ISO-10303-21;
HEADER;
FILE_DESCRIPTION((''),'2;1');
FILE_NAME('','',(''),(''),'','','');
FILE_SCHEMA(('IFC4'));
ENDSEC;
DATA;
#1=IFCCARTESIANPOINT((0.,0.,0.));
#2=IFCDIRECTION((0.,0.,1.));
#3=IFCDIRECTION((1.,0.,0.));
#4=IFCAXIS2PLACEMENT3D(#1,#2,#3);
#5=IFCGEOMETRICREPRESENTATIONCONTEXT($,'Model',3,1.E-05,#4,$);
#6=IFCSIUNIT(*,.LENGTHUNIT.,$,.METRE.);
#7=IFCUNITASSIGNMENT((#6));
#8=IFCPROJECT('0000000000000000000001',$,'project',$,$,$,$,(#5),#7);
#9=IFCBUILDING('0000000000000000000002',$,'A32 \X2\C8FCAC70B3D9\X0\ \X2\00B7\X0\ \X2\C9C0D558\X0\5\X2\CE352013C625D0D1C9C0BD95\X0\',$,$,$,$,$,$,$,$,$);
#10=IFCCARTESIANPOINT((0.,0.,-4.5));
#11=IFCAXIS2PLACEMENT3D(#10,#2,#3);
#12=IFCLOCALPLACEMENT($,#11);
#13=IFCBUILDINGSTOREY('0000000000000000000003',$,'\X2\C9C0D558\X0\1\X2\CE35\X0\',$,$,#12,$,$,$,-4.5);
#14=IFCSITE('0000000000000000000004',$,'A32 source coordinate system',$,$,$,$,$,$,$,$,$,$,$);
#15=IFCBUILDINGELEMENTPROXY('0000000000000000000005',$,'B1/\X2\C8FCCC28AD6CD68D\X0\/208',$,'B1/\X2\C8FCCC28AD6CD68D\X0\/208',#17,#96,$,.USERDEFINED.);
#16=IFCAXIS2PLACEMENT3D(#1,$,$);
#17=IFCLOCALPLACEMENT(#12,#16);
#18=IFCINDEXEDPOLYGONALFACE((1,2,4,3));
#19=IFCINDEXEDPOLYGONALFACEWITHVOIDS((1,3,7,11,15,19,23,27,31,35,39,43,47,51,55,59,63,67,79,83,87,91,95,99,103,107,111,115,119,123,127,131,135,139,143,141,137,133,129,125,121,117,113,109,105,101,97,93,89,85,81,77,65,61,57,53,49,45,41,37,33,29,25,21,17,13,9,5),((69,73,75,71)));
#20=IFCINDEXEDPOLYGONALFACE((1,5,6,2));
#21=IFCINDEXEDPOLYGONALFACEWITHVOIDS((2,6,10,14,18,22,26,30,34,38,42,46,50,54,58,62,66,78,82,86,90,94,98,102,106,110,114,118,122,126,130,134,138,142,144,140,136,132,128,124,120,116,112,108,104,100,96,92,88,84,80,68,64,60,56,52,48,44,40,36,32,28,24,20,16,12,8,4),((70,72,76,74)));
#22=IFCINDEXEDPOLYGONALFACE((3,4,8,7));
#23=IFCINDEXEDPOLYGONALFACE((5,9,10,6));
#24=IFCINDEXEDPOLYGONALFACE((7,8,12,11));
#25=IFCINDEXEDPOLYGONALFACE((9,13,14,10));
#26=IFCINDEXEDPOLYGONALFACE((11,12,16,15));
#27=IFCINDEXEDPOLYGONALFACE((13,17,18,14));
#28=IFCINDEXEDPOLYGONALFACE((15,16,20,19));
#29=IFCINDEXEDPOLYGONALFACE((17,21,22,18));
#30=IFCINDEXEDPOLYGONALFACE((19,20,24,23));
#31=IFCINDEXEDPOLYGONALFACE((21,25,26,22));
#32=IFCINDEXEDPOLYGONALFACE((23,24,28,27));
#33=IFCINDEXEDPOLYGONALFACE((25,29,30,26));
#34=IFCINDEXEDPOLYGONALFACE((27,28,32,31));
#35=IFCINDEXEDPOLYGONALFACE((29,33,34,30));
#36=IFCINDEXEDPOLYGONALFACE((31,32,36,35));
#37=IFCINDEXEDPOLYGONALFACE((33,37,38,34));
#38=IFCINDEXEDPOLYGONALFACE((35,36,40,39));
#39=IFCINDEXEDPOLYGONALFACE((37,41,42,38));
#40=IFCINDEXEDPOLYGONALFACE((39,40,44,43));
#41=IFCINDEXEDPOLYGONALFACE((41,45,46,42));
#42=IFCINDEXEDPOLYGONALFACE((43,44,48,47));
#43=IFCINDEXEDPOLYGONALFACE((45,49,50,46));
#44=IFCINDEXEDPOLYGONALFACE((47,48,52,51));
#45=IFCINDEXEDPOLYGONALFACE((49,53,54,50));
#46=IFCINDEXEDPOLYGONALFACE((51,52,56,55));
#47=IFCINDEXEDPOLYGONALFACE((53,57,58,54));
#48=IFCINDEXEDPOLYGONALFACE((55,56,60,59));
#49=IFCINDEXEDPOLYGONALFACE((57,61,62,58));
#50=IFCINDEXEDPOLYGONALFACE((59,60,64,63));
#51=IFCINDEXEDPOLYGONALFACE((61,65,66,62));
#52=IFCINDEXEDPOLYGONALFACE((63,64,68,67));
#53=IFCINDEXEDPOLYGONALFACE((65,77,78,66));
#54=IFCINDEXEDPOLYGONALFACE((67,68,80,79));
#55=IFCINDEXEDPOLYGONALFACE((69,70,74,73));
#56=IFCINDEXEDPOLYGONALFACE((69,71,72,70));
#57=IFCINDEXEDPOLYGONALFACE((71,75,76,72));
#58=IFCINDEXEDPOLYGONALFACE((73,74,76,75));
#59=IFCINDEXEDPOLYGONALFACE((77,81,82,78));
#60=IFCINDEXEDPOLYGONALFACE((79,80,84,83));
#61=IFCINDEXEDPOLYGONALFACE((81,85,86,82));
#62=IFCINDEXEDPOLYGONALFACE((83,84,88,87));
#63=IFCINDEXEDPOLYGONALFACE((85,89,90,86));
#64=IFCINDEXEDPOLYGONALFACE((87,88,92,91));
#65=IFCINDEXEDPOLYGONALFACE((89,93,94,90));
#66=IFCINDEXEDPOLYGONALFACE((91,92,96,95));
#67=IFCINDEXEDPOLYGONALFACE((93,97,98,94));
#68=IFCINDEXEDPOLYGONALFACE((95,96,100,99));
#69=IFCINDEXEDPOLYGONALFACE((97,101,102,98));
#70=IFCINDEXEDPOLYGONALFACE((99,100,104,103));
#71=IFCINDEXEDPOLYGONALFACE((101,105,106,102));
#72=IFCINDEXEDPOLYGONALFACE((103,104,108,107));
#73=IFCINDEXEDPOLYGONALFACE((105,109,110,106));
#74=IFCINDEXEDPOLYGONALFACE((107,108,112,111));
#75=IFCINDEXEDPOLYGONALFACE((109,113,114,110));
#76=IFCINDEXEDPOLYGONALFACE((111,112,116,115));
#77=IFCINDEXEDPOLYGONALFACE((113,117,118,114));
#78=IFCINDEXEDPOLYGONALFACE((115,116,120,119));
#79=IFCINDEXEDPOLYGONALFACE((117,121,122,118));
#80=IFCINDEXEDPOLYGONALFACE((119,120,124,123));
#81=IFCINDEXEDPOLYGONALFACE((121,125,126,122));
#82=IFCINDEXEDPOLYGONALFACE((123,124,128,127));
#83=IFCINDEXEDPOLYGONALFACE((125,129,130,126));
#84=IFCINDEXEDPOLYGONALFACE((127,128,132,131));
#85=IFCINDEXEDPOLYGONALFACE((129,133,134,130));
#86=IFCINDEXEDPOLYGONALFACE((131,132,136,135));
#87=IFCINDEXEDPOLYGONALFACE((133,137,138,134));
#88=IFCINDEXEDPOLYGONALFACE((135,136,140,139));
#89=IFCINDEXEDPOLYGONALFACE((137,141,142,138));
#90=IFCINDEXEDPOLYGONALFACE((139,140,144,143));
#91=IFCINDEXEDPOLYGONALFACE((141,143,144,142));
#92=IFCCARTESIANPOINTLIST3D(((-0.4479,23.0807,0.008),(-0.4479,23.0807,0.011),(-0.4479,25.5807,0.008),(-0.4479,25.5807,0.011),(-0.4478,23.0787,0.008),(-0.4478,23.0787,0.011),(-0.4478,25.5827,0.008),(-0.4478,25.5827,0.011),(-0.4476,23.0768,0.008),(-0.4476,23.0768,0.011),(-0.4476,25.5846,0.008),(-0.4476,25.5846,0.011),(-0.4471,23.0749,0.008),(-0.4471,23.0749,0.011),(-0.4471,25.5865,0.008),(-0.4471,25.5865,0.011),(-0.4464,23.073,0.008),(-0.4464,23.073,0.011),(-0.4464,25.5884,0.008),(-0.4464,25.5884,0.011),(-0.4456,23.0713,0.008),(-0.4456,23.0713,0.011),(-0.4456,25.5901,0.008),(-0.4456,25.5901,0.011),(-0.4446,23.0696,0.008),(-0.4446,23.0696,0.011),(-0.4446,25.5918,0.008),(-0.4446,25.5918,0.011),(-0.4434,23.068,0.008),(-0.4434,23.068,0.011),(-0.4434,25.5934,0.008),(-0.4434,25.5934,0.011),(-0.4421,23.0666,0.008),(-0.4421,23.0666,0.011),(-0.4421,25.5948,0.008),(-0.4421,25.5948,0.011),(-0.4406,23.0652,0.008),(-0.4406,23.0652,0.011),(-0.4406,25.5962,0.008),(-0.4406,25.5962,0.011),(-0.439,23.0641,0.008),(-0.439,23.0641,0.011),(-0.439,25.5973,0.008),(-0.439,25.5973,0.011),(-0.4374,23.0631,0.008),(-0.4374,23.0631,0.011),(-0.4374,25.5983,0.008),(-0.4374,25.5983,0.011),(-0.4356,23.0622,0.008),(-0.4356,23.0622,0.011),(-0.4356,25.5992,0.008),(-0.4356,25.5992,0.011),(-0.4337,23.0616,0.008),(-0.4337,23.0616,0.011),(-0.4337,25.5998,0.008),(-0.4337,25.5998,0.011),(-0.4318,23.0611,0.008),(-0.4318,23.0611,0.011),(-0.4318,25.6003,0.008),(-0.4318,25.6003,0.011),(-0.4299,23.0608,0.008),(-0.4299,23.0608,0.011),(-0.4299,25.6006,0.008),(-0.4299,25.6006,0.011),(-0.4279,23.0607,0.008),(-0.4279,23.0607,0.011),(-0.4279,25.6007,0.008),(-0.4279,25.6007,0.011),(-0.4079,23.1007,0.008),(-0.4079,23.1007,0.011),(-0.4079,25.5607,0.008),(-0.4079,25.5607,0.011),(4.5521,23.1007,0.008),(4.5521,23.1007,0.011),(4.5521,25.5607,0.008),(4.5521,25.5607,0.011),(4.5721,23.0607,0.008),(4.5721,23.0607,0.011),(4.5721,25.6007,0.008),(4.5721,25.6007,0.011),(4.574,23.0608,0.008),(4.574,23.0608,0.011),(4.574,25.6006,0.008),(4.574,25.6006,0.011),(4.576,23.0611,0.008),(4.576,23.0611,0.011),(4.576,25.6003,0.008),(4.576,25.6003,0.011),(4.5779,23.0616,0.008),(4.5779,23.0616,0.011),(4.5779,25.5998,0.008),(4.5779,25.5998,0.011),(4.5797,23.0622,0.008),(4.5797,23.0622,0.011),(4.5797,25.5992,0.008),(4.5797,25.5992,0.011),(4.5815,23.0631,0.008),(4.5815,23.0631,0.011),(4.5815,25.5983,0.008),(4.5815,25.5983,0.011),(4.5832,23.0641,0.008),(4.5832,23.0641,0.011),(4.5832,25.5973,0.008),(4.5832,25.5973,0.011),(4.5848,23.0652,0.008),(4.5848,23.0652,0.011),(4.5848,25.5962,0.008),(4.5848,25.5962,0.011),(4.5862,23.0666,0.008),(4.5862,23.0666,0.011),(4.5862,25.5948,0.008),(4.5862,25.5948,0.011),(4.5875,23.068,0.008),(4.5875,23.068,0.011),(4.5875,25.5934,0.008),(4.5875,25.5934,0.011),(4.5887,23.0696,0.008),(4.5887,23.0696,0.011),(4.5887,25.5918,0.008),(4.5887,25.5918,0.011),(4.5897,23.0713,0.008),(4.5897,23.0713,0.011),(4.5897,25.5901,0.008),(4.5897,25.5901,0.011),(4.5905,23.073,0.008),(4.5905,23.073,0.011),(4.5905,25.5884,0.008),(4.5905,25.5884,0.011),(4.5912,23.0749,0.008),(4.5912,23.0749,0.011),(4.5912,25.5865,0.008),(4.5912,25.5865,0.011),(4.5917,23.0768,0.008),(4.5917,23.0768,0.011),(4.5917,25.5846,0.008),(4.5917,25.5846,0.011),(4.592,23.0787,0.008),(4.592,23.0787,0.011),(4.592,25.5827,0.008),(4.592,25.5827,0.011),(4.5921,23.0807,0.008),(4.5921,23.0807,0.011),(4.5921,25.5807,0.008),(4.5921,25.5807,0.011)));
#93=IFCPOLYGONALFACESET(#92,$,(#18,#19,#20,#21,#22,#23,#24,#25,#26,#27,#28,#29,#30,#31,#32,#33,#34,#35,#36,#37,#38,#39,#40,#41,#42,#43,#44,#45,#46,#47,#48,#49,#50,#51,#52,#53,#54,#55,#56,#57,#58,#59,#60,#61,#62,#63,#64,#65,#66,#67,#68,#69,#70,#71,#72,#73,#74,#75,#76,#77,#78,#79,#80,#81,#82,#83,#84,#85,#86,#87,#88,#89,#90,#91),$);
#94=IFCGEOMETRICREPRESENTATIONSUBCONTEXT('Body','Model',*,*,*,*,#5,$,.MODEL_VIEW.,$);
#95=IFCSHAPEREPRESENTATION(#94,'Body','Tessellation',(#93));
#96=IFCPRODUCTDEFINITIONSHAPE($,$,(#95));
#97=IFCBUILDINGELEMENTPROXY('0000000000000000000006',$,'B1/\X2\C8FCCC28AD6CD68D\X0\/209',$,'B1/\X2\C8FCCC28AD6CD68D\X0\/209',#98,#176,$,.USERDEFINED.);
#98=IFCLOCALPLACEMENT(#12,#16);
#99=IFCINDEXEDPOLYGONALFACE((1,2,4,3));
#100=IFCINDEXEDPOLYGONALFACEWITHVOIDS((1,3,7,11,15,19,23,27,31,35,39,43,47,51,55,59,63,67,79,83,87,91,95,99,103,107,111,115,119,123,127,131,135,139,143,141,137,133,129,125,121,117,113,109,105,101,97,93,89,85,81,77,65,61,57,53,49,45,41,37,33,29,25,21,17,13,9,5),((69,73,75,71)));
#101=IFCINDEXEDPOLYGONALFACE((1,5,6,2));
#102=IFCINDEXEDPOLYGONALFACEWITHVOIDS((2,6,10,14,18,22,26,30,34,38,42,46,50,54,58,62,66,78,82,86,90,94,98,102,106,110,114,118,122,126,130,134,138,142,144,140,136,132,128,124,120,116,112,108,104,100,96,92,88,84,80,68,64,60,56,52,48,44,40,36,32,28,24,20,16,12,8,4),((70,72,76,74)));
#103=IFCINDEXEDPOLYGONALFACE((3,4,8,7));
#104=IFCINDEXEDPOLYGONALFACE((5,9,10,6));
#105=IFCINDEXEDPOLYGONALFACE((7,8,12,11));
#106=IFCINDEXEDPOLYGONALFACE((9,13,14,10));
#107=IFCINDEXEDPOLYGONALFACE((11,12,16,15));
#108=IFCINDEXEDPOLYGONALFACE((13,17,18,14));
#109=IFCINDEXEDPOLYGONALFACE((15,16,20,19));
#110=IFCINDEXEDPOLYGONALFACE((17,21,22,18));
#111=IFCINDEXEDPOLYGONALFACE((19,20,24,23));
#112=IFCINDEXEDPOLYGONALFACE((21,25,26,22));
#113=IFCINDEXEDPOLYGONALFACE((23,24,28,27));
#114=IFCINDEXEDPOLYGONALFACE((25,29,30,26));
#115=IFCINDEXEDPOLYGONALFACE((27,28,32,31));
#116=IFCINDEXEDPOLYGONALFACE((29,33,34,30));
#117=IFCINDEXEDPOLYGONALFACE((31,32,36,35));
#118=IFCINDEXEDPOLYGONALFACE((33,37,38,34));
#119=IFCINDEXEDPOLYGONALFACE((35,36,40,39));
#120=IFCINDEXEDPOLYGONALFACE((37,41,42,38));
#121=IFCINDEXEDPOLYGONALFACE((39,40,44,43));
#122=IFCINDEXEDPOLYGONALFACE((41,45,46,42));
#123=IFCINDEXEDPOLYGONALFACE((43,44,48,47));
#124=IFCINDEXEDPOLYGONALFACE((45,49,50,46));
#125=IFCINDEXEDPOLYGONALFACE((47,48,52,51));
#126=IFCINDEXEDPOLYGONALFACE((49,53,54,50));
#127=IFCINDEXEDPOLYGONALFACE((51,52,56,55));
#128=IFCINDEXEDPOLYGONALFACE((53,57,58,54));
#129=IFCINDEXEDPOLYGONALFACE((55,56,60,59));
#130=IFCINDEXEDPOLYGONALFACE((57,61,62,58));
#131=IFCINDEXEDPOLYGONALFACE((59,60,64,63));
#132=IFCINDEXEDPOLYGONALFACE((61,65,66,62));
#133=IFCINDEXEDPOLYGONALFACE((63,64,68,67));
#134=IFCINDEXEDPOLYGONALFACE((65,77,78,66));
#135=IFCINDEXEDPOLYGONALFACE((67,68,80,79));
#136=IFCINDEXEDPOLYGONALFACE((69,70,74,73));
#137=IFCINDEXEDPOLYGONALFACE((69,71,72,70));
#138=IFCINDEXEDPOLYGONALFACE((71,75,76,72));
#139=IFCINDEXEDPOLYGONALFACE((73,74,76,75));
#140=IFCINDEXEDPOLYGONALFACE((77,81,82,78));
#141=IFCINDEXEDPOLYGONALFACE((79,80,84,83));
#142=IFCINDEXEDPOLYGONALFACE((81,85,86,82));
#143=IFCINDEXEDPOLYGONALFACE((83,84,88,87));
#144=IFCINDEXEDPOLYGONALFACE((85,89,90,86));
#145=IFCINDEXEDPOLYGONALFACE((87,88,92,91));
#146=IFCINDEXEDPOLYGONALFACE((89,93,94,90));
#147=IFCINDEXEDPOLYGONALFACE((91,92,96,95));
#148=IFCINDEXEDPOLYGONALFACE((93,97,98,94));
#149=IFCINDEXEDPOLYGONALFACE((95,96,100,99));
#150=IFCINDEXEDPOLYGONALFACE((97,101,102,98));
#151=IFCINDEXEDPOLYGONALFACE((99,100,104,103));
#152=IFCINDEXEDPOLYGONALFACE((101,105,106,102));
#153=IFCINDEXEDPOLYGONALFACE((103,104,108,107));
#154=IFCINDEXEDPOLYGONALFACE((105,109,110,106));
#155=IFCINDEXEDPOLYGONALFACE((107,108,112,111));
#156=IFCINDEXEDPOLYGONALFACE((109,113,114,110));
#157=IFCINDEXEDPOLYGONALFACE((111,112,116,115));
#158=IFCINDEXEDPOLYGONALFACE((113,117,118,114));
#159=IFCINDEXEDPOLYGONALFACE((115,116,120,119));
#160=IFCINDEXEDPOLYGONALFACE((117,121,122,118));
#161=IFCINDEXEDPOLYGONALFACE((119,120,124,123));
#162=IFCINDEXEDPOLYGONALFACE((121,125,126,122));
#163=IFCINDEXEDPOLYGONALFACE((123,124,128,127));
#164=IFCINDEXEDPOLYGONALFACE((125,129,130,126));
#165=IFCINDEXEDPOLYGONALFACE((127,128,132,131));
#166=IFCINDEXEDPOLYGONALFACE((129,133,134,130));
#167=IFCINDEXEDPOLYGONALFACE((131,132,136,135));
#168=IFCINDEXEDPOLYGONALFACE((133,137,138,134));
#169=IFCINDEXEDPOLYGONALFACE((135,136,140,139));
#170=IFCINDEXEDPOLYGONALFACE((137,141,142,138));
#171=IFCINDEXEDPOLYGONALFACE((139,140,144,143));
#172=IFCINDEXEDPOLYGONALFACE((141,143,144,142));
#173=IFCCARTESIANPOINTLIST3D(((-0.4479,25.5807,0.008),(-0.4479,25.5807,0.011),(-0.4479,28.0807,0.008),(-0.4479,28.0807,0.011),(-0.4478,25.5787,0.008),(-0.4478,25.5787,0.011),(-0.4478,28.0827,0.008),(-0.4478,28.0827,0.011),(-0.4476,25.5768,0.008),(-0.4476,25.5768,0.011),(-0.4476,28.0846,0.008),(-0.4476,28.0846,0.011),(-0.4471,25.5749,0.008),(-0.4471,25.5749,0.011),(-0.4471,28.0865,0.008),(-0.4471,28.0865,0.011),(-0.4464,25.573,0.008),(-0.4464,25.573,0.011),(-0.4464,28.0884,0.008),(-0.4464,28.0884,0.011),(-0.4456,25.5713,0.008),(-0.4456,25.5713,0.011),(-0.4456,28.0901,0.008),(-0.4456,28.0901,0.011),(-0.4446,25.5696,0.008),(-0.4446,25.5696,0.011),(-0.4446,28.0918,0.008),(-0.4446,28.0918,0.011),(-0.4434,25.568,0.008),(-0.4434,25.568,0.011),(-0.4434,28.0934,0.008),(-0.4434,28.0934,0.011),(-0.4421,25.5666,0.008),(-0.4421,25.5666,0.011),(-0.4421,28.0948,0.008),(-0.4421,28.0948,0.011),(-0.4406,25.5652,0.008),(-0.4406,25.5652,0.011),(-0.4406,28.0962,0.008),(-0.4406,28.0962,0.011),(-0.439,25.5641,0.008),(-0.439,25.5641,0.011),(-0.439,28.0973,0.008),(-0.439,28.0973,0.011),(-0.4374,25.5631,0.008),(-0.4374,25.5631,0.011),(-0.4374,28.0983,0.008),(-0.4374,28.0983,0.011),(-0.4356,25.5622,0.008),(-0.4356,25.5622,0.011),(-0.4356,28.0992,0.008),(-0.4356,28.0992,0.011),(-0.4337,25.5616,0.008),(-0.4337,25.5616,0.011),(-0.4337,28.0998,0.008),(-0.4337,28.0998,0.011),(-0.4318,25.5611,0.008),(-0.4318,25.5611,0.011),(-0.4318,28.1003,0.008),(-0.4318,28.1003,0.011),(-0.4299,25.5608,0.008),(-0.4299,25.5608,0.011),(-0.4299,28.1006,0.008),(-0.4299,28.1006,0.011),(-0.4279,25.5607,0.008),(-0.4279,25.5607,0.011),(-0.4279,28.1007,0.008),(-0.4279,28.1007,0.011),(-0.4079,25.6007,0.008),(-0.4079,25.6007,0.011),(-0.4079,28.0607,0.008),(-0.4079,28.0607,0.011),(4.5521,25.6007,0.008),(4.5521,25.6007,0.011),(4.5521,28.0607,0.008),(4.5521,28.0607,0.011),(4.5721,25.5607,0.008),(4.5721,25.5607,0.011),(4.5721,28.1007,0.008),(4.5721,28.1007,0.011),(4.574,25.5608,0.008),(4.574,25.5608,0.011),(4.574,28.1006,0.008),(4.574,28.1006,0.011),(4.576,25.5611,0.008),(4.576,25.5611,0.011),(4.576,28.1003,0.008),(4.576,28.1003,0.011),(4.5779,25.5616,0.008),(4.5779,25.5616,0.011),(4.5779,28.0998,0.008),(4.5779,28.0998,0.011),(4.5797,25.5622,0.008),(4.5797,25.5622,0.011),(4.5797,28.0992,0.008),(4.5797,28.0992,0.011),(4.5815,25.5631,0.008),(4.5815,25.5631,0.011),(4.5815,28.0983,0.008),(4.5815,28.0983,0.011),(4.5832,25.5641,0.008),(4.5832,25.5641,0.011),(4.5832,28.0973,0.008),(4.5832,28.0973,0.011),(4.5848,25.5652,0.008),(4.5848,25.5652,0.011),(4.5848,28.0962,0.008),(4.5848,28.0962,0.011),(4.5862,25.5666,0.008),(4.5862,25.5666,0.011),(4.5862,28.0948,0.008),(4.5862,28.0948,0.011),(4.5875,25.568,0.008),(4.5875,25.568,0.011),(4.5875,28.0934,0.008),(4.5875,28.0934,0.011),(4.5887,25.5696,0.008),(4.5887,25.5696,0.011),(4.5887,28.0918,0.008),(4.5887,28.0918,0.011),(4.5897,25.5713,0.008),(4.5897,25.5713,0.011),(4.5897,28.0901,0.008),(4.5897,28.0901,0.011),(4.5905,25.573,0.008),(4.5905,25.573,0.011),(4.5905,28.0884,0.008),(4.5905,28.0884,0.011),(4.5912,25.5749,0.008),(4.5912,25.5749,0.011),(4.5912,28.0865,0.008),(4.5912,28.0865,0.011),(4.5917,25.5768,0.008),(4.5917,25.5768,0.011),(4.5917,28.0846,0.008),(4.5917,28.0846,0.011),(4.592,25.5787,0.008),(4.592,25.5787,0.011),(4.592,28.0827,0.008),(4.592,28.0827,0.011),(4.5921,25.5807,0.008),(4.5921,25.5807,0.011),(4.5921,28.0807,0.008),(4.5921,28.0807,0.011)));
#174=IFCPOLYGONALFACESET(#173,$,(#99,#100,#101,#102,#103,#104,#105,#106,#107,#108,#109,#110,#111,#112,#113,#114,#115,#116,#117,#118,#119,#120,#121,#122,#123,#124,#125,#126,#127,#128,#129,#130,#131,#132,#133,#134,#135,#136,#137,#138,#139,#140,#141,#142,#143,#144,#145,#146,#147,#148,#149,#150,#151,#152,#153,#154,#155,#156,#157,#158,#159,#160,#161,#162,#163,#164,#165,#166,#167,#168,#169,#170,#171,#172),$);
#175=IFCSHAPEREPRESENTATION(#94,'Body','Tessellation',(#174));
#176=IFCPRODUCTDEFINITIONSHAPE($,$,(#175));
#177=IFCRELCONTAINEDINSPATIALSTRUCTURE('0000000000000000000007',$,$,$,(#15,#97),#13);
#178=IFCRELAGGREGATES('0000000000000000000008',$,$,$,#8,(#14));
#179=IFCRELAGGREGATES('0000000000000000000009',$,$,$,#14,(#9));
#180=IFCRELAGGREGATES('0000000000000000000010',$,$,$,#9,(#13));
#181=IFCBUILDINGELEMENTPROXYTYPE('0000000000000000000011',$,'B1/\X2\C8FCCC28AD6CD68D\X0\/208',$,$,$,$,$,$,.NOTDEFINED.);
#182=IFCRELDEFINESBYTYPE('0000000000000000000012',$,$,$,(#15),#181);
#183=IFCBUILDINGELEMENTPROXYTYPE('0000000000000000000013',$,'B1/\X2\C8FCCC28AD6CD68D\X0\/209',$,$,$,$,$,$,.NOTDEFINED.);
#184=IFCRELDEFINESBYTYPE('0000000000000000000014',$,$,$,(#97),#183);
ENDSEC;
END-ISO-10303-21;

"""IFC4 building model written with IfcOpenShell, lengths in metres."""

from ifc_helpers import new_model, si_unit, frame, origin, origin_with_axes, place, context, subcontext, project, spatial, polyline, outline, extrude, source, transform, mapped, type_object, type_shapes, element, save


model = new_model("IFC4")

# Units and contexts
model_context = context("Model", 3, precision=1e-05, world=origin_with_axes())
body_context = subcontext(model_context, "Body", "Model", "MODEL_VIEW")
ifc_project = project(units=[si_unit("LENGTHUNIT", "METRE")], contexts=[model_context])

# Site, building, storey
site = spatial("IfcSite", under=ifc_project, Name="A32 source coordinate system")
building = spatial("IfcBuilding", under=site, Name="A32 주거동 · 지하5층–옥탑지붕")
storey_placement = place(None, frame((0.0, 0.0, -4.5), z_axis=(0.0, 0.0, 1.0), x_axis=(1.0, 0.0, 0.0)))
storey = spatial("IfcBuildingStorey", under=building, at=storey_placement, Name="지하1층", Elevation=-4.5)

# Building element proxies
building_element_proxy_type_1 = type_object("IfcBuildingElementProxyType", Name="B1/주차구획/208", PredefinedType="NOTDEFINED")
shared_shape_1 = source(origin(), body_context, "Body", "SweptSolid", [
    extrude(outline(polyline([(-0.4279, 23.0607), (-0.4299, 23.0608), (-0.4318, 23.0611), (-0.4337, 23.0616), (-0.4356, 23.0622), (-0.4374, 23.0631), (-0.439, 23.0641), (-0.4406, 23.0652), (-0.4421, 23.0666), (-0.4434, 23.068), (-0.4446, 23.0696), (-0.4456, 23.0713), (-0.4464, 23.073), (-0.4471, 23.0749), (-0.4476, 23.0768), (-0.4478, 23.0787), (-0.4479, 23.0807), (-0.4479, 25.5807), (-0.4478, 25.5827), (-0.4476, 25.5846), (-0.4471, 25.5865), (-0.4464, 25.5884), (-0.4456, 25.5901), (-0.4446, 25.5918), (-0.4434, 25.5934), (-0.4421, 25.5948), (-0.4406, 25.5962), (-0.439, 25.5973), (-0.4374, 25.5983), (-0.4356, 25.5992), (-0.4337, 25.5998), (-0.4318, 25.6003), (-0.4299, 25.6006), (-0.4279, 25.6007), (4.5721, 25.6007), (4.574, 25.6006), (4.576, 25.6003), (4.5779, 25.5998), (4.5797, 25.5992), (4.5815, 25.5983), (4.5832, 25.5973), (4.5848, 25.5962), (4.5862, 25.5948), (4.5875, 25.5934), (4.5887, 25.5918), (4.5897, 25.5901), (4.5905, 25.5884), (4.5912, 25.5865), (4.5917, 25.5846), (4.592, 25.5827), (4.5921, 25.5807), (4.5921, 23.0807), (4.592, 23.0787), (4.5917, 23.0768), (4.5912, 23.0749), (4.5905, 23.073), (4.5897, 23.0713), (4.5887, 23.0696), (4.5875, 23.068), (4.5862, 23.0666), (4.5848, 23.0652), (4.5832, 23.0641), (4.5815, 23.0631), (4.5797, 23.0622), (4.5779, 23.0616), (4.576, 23.0611), (4.574, 23.0608), (4.5721, 23.0607), (-0.4279, 23.0607)]), holes=[polyline([(-0.4079, 23.1007), (4.5521, 23.1007), (4.5521, 25.5607), (-0.4079, 25.5607), (-0.4079, 23.1007)])]), frame((0.0, 0.0, 0.008)), (0.0, 0.0, 1.0), 0.003),
])
type_shapes(building_element_proxy_type_1, [shared_shape_1])
proxy_1_placement = place(storey_placement, origin_with_axes())
element("IfcBuildingElementProxy", 1, at=proxy_1_placement, inside=storey, type_object=building_element_proxy_type_1, Name="B1/주차구획/208", ObjectType="B1/주차구획/208", PredefinedType="USERDEFINED", context=body_context, shape_type="MappedRepresentation", body=[
    mapped(shared_shape_1, transform((0.0, 0.0, 0.0), scale=1.0)),
])
building_element_proxy_type_2 = type_object("IfcBuildingElementProxyType", Name="B1/주차구획/209", PredefinedType="NOTDEFINED")
shared_shape_2 = source(origin(), body_context, "Body", "SweptSolid", [
    extrude(outline(polyline([(-0.4279, 25.5607), (-0.4299, 25.5608), (-0.4318, 25.5611), (-0.4337, 25.5616), (-0.4356, 25.5622), (-0.4374, 25.5631), (-0.439, 25.5641), (-0.4406, 25.5652), (-0.4421, 25.5666), (-0.4434, 25.568), (-0.4446, 25.5696), (-0.4456, 25.5713), (-0.4464, 25.573), (-0.4471, 25.5749), (-0.4476, 25.5768), (-0.4478, 25.5787), (-0.4479, 25.5807), (-0.4479, 28.0807), (-0.4478, 28.0827), (-0.4476, 28.0846), (-0.4471, 28.0865), (-0.4464, 28.0884), (-0.4456, 28.0901), (-0.4446, 28.0918), (-0.4434, 28.0934), (-0.4421, 28.0948), (-0.4406, 28.0962), (-0.439, 28.0973), (-0.4374, 28.0983), (-0.4356, 28.0992), (-0.4337, 28.0998), (-0.4318, 28.1003), (-0.4299, 28.1006), (-0.4279, 28.1007), (4.5721, 28.1007), (4.574, 28.1006), (4.576, 28.1003), (4.5779, 28.0998), (4.5797, 28.0992), (4.5815, 28.0983), (4.5832, 28.0973), (4.5848, 28.0962), (4.5862, 28.0948), (4.5875, 28.0934), (4.5887, 28.0918), (4.5897, 28.0901), (4.5905, 28.0884), (4.5912, 28.0865), (4.5917, 28.0846), (4.592, 28.0827), (4.5921, 28.0807), (4.5921, 25.5807), (4.592, 25.5787), (4.5917, 25.5768), (4.5912, 25.5749), (4.5905, 25.573), (4.5897, 25.5713), (4.5887, 25.5696), (4.5875, 25.568), (4.5862, 25.5666), (4.5848, 25.5652), (4.5832, 25.5641), (4.5815, 25.5631), (4.5797, 25.5622), (4.5779, 25.5616), (4.576, 25.5611), (4.574, 25.5608), (4.5721, 25.5607), (-0.4279, 25.5607)]), holes=[polyline([(-0.4079, 25.6007), (4.5521, 25.6007), (4.5521, 28.0607), (-0.4079, 28.0607), (-0.4079, 25.6007)])]), frame((0.0, 0.0, 0.008)), (0.0, 0.0, 1.0), 0.003),
])
type_shapes(building_element_proxy_type_2, [shared_shape_2])
proxy_2_placement = place(storey_placement, origin_with_axes())
element("IfcBuildingElementProxy", 2, at=proxy_2_placement, inside=storey, type_object=building_element_proxy_type_2, Name="B1/주차구획/209", ObjectType="B1/주차구획/209", PredefinedType="USERDEFINED", context=body_context, shape_type="MappedRepresentation", body=[
    mapped(shared_shape_2, transform((0.0, 0.0, 0.0), scale=1.0)),
])

save(model, "model.ifc")
